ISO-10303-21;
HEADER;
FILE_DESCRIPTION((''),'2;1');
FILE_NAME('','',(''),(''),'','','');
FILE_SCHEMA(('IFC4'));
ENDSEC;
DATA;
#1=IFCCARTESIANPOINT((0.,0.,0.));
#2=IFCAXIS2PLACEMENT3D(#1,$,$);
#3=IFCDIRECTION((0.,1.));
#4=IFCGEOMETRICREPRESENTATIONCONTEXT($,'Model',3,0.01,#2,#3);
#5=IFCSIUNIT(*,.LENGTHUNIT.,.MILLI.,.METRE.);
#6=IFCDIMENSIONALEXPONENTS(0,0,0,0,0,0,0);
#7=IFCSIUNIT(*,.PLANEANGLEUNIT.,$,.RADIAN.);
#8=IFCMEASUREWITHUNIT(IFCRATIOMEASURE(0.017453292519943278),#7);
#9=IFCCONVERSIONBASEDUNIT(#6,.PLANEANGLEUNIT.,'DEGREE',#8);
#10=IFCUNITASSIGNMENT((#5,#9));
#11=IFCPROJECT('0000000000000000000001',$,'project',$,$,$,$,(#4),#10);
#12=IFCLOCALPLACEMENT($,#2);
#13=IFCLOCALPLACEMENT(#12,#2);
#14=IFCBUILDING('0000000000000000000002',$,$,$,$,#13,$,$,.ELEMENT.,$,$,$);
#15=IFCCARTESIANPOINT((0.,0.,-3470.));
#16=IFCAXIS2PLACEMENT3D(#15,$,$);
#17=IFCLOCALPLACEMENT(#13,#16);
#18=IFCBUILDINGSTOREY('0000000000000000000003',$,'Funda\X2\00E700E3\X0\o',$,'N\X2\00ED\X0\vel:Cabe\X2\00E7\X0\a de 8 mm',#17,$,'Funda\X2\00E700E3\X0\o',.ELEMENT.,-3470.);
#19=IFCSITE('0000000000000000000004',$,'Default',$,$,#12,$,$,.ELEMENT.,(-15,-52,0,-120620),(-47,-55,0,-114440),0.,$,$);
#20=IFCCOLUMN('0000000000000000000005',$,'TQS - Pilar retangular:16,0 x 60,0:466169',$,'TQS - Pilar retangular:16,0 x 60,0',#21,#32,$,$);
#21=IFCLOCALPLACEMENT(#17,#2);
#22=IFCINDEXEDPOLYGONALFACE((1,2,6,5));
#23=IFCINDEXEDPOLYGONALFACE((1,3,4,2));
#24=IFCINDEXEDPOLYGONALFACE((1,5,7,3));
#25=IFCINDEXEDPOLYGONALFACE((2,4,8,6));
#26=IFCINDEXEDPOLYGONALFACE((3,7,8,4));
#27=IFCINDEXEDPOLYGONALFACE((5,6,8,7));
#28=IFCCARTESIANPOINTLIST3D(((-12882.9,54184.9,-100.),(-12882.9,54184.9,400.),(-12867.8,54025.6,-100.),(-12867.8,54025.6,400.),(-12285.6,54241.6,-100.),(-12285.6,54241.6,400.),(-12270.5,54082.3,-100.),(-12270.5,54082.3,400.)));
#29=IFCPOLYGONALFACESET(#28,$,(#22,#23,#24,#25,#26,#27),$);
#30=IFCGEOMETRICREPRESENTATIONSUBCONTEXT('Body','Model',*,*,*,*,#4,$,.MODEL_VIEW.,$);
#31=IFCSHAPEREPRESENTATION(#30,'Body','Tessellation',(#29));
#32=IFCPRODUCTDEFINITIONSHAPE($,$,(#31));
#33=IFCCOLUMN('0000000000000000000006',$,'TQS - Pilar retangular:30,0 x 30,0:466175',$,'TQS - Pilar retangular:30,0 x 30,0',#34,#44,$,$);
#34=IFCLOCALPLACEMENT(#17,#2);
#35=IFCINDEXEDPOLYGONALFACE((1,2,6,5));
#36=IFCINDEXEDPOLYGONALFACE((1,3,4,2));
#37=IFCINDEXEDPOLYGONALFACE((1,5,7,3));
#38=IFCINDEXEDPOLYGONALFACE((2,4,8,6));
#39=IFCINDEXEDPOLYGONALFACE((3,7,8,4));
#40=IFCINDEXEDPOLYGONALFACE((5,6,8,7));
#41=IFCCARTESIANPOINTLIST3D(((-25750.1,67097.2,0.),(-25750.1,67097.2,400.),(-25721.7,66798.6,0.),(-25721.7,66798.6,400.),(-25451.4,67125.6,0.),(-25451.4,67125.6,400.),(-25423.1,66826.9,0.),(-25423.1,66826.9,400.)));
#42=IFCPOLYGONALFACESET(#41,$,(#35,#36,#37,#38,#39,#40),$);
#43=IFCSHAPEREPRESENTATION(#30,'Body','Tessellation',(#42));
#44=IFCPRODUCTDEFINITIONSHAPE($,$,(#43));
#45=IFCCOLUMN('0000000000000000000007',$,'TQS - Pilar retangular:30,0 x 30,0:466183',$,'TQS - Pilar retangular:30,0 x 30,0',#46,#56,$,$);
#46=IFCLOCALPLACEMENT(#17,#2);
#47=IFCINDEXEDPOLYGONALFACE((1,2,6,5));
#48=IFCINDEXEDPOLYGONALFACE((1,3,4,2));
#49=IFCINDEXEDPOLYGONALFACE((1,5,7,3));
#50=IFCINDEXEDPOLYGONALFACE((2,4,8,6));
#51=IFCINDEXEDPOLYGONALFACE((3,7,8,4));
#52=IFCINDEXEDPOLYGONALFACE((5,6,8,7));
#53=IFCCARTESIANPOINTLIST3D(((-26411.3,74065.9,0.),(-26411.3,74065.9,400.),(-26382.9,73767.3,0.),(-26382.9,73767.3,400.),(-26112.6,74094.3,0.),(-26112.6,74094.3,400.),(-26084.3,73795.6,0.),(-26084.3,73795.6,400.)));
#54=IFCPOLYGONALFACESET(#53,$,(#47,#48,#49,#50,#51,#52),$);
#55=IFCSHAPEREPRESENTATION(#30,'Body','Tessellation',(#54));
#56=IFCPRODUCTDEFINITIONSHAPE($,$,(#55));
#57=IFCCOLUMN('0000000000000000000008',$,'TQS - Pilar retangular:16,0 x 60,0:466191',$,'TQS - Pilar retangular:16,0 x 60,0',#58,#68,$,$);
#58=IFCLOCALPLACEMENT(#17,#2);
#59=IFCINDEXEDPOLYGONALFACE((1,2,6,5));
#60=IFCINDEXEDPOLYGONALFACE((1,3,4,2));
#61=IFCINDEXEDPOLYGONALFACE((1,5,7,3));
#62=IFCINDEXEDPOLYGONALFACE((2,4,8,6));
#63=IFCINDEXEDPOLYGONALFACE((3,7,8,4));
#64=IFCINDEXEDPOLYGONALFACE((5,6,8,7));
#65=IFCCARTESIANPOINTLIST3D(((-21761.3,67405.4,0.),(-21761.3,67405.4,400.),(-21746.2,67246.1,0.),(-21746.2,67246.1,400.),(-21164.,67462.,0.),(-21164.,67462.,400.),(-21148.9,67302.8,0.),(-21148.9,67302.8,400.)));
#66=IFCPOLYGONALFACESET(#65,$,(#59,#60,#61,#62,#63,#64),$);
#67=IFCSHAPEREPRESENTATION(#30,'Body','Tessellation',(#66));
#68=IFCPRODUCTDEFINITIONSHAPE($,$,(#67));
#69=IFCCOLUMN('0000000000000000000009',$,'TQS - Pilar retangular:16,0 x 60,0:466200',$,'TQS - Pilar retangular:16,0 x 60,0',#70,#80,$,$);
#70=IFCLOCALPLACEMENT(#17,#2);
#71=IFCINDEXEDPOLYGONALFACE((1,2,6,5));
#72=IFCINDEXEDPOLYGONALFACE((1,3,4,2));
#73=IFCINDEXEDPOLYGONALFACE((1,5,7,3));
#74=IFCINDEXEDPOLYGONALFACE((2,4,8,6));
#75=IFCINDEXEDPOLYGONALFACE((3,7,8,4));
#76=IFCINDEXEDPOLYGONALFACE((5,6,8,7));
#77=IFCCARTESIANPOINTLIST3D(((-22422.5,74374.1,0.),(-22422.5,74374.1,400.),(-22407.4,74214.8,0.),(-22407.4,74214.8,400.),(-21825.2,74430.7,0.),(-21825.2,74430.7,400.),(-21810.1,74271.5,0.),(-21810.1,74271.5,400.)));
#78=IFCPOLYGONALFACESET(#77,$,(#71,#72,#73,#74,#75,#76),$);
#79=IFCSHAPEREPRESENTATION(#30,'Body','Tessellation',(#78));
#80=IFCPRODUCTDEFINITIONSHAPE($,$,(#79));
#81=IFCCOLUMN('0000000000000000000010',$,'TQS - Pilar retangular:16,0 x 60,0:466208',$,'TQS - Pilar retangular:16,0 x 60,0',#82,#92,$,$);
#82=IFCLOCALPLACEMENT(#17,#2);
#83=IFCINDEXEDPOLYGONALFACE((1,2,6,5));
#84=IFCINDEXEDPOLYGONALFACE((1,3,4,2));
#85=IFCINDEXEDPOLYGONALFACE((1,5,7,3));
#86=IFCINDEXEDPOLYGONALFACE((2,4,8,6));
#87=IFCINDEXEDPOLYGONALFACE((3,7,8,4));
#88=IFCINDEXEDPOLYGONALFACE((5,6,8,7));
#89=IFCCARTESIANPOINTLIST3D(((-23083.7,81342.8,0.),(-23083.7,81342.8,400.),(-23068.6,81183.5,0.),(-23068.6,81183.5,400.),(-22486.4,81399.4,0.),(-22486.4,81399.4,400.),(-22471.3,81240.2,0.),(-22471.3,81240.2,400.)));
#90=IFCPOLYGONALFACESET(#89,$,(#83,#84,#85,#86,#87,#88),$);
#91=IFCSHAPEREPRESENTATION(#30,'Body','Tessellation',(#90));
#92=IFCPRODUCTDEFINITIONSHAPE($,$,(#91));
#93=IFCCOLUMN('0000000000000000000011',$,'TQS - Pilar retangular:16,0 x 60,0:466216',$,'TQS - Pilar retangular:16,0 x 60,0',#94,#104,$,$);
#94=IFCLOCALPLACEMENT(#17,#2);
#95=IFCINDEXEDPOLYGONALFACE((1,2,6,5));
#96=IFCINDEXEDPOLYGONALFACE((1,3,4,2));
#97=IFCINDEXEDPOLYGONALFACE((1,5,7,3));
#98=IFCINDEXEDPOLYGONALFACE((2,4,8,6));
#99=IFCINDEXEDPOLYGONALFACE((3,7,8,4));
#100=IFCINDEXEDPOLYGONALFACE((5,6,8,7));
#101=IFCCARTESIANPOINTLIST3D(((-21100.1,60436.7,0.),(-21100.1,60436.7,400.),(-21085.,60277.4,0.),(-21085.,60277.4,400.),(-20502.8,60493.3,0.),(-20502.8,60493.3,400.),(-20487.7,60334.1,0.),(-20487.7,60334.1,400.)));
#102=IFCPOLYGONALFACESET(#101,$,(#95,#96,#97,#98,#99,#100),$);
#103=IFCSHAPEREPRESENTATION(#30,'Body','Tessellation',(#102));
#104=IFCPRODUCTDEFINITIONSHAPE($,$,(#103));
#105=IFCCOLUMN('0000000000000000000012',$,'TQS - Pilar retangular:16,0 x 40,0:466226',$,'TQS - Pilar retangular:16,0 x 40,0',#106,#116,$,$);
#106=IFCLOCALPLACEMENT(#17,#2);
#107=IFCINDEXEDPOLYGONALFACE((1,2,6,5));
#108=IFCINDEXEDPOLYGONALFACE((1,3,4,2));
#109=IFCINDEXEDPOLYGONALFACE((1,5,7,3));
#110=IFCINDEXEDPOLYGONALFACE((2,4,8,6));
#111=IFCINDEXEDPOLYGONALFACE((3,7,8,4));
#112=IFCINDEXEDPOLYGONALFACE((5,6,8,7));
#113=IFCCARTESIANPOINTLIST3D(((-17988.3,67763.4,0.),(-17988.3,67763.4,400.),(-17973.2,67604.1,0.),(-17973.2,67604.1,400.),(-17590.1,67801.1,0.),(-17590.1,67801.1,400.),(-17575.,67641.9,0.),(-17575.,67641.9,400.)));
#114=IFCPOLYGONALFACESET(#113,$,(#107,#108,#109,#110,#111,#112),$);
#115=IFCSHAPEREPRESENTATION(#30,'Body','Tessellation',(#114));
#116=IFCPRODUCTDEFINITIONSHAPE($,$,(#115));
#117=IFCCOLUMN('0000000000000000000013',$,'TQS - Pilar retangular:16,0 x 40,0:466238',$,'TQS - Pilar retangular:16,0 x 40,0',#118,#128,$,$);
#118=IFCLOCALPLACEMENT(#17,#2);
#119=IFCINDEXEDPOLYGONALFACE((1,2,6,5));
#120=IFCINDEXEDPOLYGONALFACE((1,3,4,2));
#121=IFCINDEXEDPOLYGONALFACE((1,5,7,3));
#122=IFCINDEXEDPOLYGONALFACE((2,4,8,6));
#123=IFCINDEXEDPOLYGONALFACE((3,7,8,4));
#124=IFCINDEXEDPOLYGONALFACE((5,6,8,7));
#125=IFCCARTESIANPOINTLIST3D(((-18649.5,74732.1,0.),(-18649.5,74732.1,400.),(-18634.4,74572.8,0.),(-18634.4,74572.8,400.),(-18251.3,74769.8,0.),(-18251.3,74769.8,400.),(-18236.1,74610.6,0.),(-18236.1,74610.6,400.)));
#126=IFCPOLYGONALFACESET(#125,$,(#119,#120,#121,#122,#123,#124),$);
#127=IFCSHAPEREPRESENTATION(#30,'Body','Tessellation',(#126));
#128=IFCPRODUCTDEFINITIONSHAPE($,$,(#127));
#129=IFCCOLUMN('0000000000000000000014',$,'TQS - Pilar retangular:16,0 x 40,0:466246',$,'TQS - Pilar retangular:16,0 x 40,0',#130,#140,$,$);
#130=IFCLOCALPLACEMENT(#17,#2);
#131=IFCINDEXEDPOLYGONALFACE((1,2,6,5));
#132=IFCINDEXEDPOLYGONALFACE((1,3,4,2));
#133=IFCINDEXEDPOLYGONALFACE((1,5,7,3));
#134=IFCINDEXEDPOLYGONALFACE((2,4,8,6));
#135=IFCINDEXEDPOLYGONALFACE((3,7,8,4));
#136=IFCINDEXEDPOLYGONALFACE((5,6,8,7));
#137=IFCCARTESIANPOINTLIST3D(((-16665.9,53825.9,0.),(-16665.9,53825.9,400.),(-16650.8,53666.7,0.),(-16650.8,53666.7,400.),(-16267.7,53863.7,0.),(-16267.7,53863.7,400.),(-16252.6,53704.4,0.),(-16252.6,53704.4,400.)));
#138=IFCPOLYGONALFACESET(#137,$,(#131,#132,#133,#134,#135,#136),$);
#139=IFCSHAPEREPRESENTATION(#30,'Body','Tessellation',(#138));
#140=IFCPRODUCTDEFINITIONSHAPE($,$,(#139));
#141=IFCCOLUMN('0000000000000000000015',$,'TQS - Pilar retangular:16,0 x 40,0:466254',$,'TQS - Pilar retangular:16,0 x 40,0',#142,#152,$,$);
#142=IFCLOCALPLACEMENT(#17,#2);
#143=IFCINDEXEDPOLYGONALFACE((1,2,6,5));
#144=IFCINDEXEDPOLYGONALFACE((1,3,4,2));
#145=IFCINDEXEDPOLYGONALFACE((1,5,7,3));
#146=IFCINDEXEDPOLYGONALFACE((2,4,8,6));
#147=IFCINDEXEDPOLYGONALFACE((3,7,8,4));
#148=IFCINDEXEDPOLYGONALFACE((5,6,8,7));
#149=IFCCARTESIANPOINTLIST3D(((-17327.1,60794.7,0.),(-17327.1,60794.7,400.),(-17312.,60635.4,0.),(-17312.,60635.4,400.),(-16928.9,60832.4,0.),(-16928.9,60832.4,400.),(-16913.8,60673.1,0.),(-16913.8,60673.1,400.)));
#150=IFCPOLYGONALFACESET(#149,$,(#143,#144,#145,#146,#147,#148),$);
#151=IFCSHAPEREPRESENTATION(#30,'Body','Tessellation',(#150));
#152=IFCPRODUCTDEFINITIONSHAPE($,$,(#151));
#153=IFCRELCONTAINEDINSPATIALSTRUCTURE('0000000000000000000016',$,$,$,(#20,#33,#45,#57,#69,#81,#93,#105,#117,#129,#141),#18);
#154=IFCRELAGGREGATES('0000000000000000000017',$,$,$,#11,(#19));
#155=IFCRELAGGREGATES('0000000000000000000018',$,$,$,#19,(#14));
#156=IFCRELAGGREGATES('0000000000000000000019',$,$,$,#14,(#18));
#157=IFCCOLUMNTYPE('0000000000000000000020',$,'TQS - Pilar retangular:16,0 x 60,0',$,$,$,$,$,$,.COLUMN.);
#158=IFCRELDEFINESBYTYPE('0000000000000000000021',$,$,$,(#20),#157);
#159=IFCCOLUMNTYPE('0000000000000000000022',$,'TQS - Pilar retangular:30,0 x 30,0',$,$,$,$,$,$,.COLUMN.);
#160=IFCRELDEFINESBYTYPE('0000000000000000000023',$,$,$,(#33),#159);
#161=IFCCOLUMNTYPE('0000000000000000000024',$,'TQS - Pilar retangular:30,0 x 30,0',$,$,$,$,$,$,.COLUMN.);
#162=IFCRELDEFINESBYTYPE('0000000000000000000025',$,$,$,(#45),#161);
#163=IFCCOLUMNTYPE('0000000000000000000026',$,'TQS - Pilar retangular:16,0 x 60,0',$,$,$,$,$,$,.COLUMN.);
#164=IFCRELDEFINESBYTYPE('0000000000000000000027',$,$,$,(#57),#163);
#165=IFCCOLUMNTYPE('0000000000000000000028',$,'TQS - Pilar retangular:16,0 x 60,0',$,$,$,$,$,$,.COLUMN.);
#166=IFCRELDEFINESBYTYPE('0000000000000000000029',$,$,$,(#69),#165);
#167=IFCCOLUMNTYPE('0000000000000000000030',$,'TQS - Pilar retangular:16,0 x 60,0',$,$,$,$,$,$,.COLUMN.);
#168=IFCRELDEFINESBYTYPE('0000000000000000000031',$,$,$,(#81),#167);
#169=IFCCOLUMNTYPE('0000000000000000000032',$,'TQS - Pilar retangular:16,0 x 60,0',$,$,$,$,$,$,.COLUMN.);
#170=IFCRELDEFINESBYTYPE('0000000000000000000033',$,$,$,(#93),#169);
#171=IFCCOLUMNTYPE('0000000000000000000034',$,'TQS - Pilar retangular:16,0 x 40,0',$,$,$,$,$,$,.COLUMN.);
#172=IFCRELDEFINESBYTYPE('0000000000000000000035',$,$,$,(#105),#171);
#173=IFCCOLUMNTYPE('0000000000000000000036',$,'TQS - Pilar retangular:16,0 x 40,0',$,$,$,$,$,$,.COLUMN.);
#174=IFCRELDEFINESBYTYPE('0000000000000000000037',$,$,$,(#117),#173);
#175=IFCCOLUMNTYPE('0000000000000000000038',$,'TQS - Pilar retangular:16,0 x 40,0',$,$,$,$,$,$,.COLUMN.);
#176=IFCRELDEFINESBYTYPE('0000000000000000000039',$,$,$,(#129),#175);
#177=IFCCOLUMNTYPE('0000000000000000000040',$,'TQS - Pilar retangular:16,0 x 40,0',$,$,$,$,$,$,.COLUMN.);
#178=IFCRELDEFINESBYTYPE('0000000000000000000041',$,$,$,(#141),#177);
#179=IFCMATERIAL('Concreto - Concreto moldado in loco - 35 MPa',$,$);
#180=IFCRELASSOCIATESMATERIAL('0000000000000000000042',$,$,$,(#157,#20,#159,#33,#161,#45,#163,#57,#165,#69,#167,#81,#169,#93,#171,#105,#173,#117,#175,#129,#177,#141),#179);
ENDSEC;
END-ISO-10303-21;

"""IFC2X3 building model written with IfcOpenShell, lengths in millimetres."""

from ifc_helpers import new_model, entity, si_unit, converted_unit, direction, frame, frame_2d, origin, origin_2d_with_axis, place, context, subcontext, project, spatial, rectangle, extrude, source, transform, mapped, material, type_object, type_shapes, element, save


model = new_model("IFC2X3")

# Units and contexts
model_context = context("Model", 3, precision=0.01, world=origin(), true_north=direction((0.0, 1.0)))
body_context = subcontext(model_context, "Body", "Model", "MODEL_VIEW")
ifc_project = project(units=[si_unit("LENGTHUNIT", "METRE", prefix="MILLI"), converted_unit("PLANEANGLEUNIT", "DEGREE", entity("IfcRatioMeasure", 0.017453292519943278), si_unit("PLANEANGLEUNIT", "RADIAN"), dimensions=[0, 0, 0, 0, 0, 0, 0])], contexts=[model_context])

# Site, building, storey
site_placement = place(None, origin())
site = spatial("IfcSite", under=ifc_project, at=site_placement, Name="Default", CompositionType="ELEMENT", RefLatitude=(-15, -52, 0, -120620), RefLongitude=(-47, -55, 0, -114440), RefElevation=0.0)
building_placement = place(site_placement, origin())
building = spatial("IfcBuilding", under=site, at=building_placement, CompositionType="ELEMENT")
storey_placement = place(building_placement, frame((0.0, 0.0, -3470.0)))
storey = spatial("IfcBuildingStorey", under=building, at=storey_placement, Name="Fundação", ObjectType="Nível:Cabeça de 8 mm", LongName="Fundação", CompositionType="ELEMENT", Elevation=-3470.0)

# Columns
ifc_material_1 = material(Name="Concreto - Concreto moldado in loco - 35 MPa")
column_type_1 = type_object("IfcColumnType", Name="TQS - Pilar retangular:16,0 x 60,0", PredefinedType="COLUMN", material=ifc_material_1)
shared_shape_1 = source(origin(), body_context, "Body", "SweptSolid", [
    extrude(rectangle(XDim=600.0, YDim=160.0, at=frame_2d((0.0, 0.0), x_axis=(1.0, 0.0))), frame((-12576.7, 54133.6, -3570.0), z_axis=(0.0, 0.0, 1.0), x_axis=(-0.995529, -0.094456, 0.0)), (0.0, 0.0, 1.0), 500.0),
])
type_shapes(column_type_1, [shared_shape_1])
column_1_placement = place(storey_placement, frame((0.0, 0.0, 3470.0)))
element("IfcColumn", 1, at=column_1_placement, inside=storey, type_object=column_type_1, material=ifc_material_1, Name="TQS - Pilar retangular:16,0 x 60,0:466169", ObjectType="TQS - Pilar retangular:16,0 x 60,0", context=body_context, shape_type="MappedRepresentation", body=[
    mapped(shared_shape_1, transform((0.0, 0.0, 0.0), scale=1.0)),
])
column_type_2 = type_object("IfcColumnType", Name="TQS - Pilar retangular:30,0 x 30,0", PredefinedType="COLUMN", material=ifc_material_1)
shared_shape_2 = source(origin(), body_context, "Body", "SweptSolid", [
    extrude(rectangle(XDim=300.0, YDim=300.0, at=origin_2d_with_axis()), frame((-25586.6, 66962.1, -3470.0), z_axis=(0.0, 0.0, 1.0), x_axis=(-0.995529, -0.094456, 0.0)), (0.0, 0.0, 1.0), 400.0),
])
type_shapes(column_type_2, [shared_shape_2])
column_2_placement = place(storey_placement, frame((0.0, 0.0, 3470.0)))
element("IfcColumn", 2, at=column_2_placement, inside=storey, type_object=column_type_2, material=ifc_material_1, Name="TQS - Pilar retangular:30,0 x 30,0:466175", ObjectType="TQS - Pilar retangular:30,0 x 30,0", context=body_context, shape_type="MappedRepresentation", body=[
    mapped(shared_shape_2, transform((0.0, 0.0, 0.0), scale=1.0)),
])
column_type_3 = type_object("IfcColumnType", Name="TQS - Pilar retangular:30,0 x 30,0", PredefinedType="COLUMN", material=ifc_material_1)
shared_shape_3 = source(origin(), body_context, "Body", "SweptSolid", [
    extrude(rectangle(XDim=300.0, YDim=300.0, at=origin_2d_with_axis()), frame((-26247.8, 73930.8, -3470.0), z_axis=(0.0, 0.0, 1.0), x_axis=(-0.995529, -0.094456, 0.0)), (0.0, 0.0, 1.0), 400.0),
])
type_shapes(column_type_3, [shared_shape_3])
column_3_placement = place(storey_placement, frame((0.0, 0.0, 3470.0)))
element("IfcColumn", 3, at=column_3_placement, inside=storey, type_object=column_type_3, material=ifc_material_1, Name="TQS - Pilar retangular:30,0 x 30,0:466183", ObjectType="TQS - Pilar retangular:30,0 x 30,0", context=body_context, shape_type="MappedRepresentation", body=[
    mapped(shared_shape_3, transform((0.0, 0.0, 0.0), scale=1.0)),
])
column_type_4 = type_object("IfcColumnType", Name="TQS - Pilar retangular:16,0 x 60,0", PredefinedType="COLUMN", material=ifc_material_1)
shared_shape_4 = source(origin(), body_context, "Body", "SweptSolid", [
    extrude(rectangle(XDim=600.0, YDim=160.0, at=origin_2d_with_axis()), frame((-21455.1, 67354.1, -3470.0), z_axis=(0.0, 0.0, 1.0), x_axis=(-0.995529, -0.094456, 0.0)), (0.0, 0.0, 1.0), 400.0),
])
type_shapes(column_type_4, [shared_shape_4])
column_4_placement = place(storey_placement, frame((0.0, 0.0, 3470.0)))
element("IfcColumn", 4, at=column_4_placement, inside=storey, type_object=column_type_4, material=ifc_material_1, Name="TQS - Pilar retangular:16,0 x 60,0:466191", ObjectType="TQS - Pilar retangular:16,0 x 60,0", context=body_context, shape_type="MappedRepresentation", body=[
    mapped(shared_shape_4, transform((0.0, 0.0, 0.0), scale=1.0)),
])
column_type_5 = type_object("IfcColumnType", Name="TQS - Pilar retangular:16,0 x 60,0", PredefinedType="COLUMN", material=ifc_material_1)
shared_shape_5 = source(origin(), body_context, "Body", "SweptSolid", [
    extrude(rectangle(XDim=600.0, YDim=160.0, at=origin_2d_with_axis()), frame((-22116.3, 74322.8, -3470.0), z_axis=(0.0, 0.0, 1.0), x_axis=(-0.995529, -0.094456, 0.0)), (0.0, 0.0, 1.0), 400.0),
])
type_shapes(column_type_5, [shared_shape_5])
column_5_placement = place(storey_placement, frame((0.0, 0.0, 3470.0)))
element("IfcColumn", 5, at=column_5_placement, inside=storey, type_object=column_type_5, material=ifc_material_1, Name="TQS - Pilar retangular:16,0 x 60,0:466200", ObjectType="TQS - Pilar retangular:16,0 x 60,0", context=body_context, shape_type="MappedRepresentation", body=[
    mapped(shared_shape_5, transform((0.0, 0.0, 0.0), scale=1.0)),
])
column_type_6 = type_object("IfcColumnType", Name="TQS - Pilar retangular:16,0 x 60,0", PredefinedType="COLUMN", material=ifc_material_1)
shared_shape_6 = source(origin(), body_context, "Body", "SweptSolid", [
    extrude(rectangle(XDim=600.0, YDim=160.0, at=origin_2d_with_axis()), frame((-22777.5, 81291.5, -3470.0), z_axis=(0.0, 0.0, 1.0), x_axis=(-0.995529, -0.094456, 0.0)), (0.0, 0.0, 1.0), 400.0),
])
type_shapes(column_type_6, [shared_shape_6])
column_6_placement = place(storey_placement, frame((0.0, 0.0, 3470.0)))
element("IfcColumn", 6, at=column_6_placement, inside=storey, type_object=column_type_6, material=ifc_material_1, Name="TQS - Pilar retangular:16,0 x 60,0:466208", ObjectType="TQS - Pilar retangular:16,0 x 60,0", context=body_context, shape_type="MappedRepresentation", body=[
    mapped(shared_shape_6, transform((0.0, 0.0, 0.0), scale=1.0)),
])
column_type_7 = type_object("IfcColumnType", Name="TQS - Pilar retangular:16,0 x 60,0", PredefinedType="COLUMN", material=ifc_material_1)
shared_shape_7 = source(origin(), body_context, "Body", "SweptSolid", [
    extrude(rectangle(XDim=600.0, YDim=160.0, at=origin_2d_with_axis()), frame((-20793.9, 60385.4, -3470.0), z_axis=(0.0, 0.0, 1.0), x_axis=(-0.995529, -0.094456, 0.0)), (0.0, 0.0, 1.0), 400.0),
])
type_shapes(column_type_7, [shared_shape_7])
column_7_placement = place(storey_placement, frame((0.0, 0.0, 3470.0)))
element("IfcColumn", 7, at=column_7_placement, inside=storey, type_object=column_type_7, material=ifc_material_1, Name="TQS - Pilar retangular:16,0 x 60,0:466216", ObjectType="TQS - Pilar retangular:16,0 x 60,0", context=body_context, shape_type="MappedRepresentation", body=[
    mapped(shared_shape_7, transform((0.0, 0.0, 0.0), scale=1.0)),
])
column_type_8 = type_object("IfcColumnType", Name="TQS - Pilar retangular:16,0 x 40,0", PredefinedType="COLUMN", material=ifc_material_1)
shared_shape_8 = source(origin(), body_context, "Body", "SweptSolid", [
    extrude(rectangle(XDim=400.0, YDim=160.0, at=origin_2d_with_axis()), frame((-17781.6, 67702.6, -3470.0), z_axis=(0.0, 0.0, 1.0), x_axis=(-0.995529, -0.094456, 0.0)), (0.0, 0.0, 1.0), 400.0),
])
type_shapes(column_type_8, [shared_shape_8])
column_8_placement = place(storey_placement, frame((0.0, 0.0, 3470.0)))
element("IfcColumn", 8, at=column_8_placement, inside=storey, type_object=column_type_8, material=ifc_material_1, Name="TQS - Pilar retangular:16,0 x 40,0:466226", ObjectType="TQS - Pilar retangular:16,0 x 40,0", context=body_context, shape_type="MappedRepresentation", body=[
    mapped(shared_shape_8, transform((0.0, 0.0, 0.0), scale=1.0)),
])
column_type_9 = type_object("IfcColumnType", Name="TQS - Pilar retangular:16,0 x 40,0", PredefinedType="COLUMN", material=ifc_material_1)
shared_shape_9 = source(origin(), body_context, "Body", "SweptSolid", [
    extrude(rectangle(XDim=400.0, YDim=160.0, at=origin_2d_with_axis()), frame((-18442.8, 74671.3, -3470.0), z_axis=(0.0, 0.0, 1.0), x_axis=(-0.995529, -0.094456, 0.0)), (0.0, 0.0, 1.0), 400.0),
])
type_shapes(column_type_9, [shared_shape_9])
column_9_placement = place(storey_placement, frame((0.0, 0.0, 3470.0)))
element("IfcColumn", 9, at=column_9_placement, inside=storey, type_object=column_type_9, material=ifc_material_1, Name="TQS - Pilar retangular:16,0 x 40,0:466238", ObjectType="TQS - Pilar retangular:16,0 x 40,0", context=body_context, shape_type="MappedRepresentation", body=[
    mapped(shared_shape_9, transform((0.0, 0.0, 0.0), scale=1.0)),
])
column_type_10 = type_object("IfcColumnType", Name="TQS - Pilar retangular:16,0 x 40,0", PredefinedType="COLUMN", material=ifc_material_1)
shared_shape_10 = source(origin(), body_context, "Body", "SweptSolid", [
    extrude(rectangle(XDim=400.0, YDim=160.0, at=origin_2d_with_axis()), frame((-16459.2, 53765.2, -3470.0), z_axis=(0.0, 0.0, 1.0), x_axis=(-0.995529, -0.094456, 0.0)), (0.0, 0.0, 1.0), 400.0),
])
type_shapes(column_type_10, [shared_shape_10])
column_10_placement = place(storey_placement, frame((0.0, 0.0, 3470.0)))
element("IfcColumn", 10, at=column_10_placement, inside=storey, type_object=column_type_10, material=ifc_material_1, Name="TQS - Pilar retangular:16,0 x 40,0:466246", ObjectType="TQS - Pilar retangular:16,0 x 40,0", context=body_context, shape_type="MappedRepresentation", body=[
    mapped(shared_shape_10, transform((0.0, 0.0, 0.0), scale=1.0)),
])
column_type_11 = type_object("IfcColumnType", Name="TQS - Pilar retangular:16,0 x 40,0", PredefinedType="COLUMN", material=ifc_material_1)
shared_shape_11 = source(origin(), body_context, "Body", "SweptSolid", [
    extrude(rectangle(XDim=400.0, YDim=160.0, at=origin_2d_with_axis()), frame((-17120.4, 60733.9, -3470.0), z_axis=(0.0, 0.0, 1.0), x_axis=(-0.995529, -0.094456, 0.0)), (0.0, 0.0, 1.0), 400.0),
])
type_shapes(column_type_11, [shared_shape_11])
column_11_placement = place(storey_placement, frame((0.0, 0.0, 3470.0)))
element("IfcColumn", 11, at=column_11_placement, inside=storey, type_object=column_type_11, material=ifc_material_1, Name="TQS - Pilar retangular:16,0 x 40,0:466254", ObjectType="TQS - Pilar retangular:16,0 x 40,0", context=body_context, shape_type="MappedRepresentation", body=[
    mapped(shared_shape_11, transform((0.0, 0.0, 0.0), scale=1.0)),
])

save(model, "model.ifc")
